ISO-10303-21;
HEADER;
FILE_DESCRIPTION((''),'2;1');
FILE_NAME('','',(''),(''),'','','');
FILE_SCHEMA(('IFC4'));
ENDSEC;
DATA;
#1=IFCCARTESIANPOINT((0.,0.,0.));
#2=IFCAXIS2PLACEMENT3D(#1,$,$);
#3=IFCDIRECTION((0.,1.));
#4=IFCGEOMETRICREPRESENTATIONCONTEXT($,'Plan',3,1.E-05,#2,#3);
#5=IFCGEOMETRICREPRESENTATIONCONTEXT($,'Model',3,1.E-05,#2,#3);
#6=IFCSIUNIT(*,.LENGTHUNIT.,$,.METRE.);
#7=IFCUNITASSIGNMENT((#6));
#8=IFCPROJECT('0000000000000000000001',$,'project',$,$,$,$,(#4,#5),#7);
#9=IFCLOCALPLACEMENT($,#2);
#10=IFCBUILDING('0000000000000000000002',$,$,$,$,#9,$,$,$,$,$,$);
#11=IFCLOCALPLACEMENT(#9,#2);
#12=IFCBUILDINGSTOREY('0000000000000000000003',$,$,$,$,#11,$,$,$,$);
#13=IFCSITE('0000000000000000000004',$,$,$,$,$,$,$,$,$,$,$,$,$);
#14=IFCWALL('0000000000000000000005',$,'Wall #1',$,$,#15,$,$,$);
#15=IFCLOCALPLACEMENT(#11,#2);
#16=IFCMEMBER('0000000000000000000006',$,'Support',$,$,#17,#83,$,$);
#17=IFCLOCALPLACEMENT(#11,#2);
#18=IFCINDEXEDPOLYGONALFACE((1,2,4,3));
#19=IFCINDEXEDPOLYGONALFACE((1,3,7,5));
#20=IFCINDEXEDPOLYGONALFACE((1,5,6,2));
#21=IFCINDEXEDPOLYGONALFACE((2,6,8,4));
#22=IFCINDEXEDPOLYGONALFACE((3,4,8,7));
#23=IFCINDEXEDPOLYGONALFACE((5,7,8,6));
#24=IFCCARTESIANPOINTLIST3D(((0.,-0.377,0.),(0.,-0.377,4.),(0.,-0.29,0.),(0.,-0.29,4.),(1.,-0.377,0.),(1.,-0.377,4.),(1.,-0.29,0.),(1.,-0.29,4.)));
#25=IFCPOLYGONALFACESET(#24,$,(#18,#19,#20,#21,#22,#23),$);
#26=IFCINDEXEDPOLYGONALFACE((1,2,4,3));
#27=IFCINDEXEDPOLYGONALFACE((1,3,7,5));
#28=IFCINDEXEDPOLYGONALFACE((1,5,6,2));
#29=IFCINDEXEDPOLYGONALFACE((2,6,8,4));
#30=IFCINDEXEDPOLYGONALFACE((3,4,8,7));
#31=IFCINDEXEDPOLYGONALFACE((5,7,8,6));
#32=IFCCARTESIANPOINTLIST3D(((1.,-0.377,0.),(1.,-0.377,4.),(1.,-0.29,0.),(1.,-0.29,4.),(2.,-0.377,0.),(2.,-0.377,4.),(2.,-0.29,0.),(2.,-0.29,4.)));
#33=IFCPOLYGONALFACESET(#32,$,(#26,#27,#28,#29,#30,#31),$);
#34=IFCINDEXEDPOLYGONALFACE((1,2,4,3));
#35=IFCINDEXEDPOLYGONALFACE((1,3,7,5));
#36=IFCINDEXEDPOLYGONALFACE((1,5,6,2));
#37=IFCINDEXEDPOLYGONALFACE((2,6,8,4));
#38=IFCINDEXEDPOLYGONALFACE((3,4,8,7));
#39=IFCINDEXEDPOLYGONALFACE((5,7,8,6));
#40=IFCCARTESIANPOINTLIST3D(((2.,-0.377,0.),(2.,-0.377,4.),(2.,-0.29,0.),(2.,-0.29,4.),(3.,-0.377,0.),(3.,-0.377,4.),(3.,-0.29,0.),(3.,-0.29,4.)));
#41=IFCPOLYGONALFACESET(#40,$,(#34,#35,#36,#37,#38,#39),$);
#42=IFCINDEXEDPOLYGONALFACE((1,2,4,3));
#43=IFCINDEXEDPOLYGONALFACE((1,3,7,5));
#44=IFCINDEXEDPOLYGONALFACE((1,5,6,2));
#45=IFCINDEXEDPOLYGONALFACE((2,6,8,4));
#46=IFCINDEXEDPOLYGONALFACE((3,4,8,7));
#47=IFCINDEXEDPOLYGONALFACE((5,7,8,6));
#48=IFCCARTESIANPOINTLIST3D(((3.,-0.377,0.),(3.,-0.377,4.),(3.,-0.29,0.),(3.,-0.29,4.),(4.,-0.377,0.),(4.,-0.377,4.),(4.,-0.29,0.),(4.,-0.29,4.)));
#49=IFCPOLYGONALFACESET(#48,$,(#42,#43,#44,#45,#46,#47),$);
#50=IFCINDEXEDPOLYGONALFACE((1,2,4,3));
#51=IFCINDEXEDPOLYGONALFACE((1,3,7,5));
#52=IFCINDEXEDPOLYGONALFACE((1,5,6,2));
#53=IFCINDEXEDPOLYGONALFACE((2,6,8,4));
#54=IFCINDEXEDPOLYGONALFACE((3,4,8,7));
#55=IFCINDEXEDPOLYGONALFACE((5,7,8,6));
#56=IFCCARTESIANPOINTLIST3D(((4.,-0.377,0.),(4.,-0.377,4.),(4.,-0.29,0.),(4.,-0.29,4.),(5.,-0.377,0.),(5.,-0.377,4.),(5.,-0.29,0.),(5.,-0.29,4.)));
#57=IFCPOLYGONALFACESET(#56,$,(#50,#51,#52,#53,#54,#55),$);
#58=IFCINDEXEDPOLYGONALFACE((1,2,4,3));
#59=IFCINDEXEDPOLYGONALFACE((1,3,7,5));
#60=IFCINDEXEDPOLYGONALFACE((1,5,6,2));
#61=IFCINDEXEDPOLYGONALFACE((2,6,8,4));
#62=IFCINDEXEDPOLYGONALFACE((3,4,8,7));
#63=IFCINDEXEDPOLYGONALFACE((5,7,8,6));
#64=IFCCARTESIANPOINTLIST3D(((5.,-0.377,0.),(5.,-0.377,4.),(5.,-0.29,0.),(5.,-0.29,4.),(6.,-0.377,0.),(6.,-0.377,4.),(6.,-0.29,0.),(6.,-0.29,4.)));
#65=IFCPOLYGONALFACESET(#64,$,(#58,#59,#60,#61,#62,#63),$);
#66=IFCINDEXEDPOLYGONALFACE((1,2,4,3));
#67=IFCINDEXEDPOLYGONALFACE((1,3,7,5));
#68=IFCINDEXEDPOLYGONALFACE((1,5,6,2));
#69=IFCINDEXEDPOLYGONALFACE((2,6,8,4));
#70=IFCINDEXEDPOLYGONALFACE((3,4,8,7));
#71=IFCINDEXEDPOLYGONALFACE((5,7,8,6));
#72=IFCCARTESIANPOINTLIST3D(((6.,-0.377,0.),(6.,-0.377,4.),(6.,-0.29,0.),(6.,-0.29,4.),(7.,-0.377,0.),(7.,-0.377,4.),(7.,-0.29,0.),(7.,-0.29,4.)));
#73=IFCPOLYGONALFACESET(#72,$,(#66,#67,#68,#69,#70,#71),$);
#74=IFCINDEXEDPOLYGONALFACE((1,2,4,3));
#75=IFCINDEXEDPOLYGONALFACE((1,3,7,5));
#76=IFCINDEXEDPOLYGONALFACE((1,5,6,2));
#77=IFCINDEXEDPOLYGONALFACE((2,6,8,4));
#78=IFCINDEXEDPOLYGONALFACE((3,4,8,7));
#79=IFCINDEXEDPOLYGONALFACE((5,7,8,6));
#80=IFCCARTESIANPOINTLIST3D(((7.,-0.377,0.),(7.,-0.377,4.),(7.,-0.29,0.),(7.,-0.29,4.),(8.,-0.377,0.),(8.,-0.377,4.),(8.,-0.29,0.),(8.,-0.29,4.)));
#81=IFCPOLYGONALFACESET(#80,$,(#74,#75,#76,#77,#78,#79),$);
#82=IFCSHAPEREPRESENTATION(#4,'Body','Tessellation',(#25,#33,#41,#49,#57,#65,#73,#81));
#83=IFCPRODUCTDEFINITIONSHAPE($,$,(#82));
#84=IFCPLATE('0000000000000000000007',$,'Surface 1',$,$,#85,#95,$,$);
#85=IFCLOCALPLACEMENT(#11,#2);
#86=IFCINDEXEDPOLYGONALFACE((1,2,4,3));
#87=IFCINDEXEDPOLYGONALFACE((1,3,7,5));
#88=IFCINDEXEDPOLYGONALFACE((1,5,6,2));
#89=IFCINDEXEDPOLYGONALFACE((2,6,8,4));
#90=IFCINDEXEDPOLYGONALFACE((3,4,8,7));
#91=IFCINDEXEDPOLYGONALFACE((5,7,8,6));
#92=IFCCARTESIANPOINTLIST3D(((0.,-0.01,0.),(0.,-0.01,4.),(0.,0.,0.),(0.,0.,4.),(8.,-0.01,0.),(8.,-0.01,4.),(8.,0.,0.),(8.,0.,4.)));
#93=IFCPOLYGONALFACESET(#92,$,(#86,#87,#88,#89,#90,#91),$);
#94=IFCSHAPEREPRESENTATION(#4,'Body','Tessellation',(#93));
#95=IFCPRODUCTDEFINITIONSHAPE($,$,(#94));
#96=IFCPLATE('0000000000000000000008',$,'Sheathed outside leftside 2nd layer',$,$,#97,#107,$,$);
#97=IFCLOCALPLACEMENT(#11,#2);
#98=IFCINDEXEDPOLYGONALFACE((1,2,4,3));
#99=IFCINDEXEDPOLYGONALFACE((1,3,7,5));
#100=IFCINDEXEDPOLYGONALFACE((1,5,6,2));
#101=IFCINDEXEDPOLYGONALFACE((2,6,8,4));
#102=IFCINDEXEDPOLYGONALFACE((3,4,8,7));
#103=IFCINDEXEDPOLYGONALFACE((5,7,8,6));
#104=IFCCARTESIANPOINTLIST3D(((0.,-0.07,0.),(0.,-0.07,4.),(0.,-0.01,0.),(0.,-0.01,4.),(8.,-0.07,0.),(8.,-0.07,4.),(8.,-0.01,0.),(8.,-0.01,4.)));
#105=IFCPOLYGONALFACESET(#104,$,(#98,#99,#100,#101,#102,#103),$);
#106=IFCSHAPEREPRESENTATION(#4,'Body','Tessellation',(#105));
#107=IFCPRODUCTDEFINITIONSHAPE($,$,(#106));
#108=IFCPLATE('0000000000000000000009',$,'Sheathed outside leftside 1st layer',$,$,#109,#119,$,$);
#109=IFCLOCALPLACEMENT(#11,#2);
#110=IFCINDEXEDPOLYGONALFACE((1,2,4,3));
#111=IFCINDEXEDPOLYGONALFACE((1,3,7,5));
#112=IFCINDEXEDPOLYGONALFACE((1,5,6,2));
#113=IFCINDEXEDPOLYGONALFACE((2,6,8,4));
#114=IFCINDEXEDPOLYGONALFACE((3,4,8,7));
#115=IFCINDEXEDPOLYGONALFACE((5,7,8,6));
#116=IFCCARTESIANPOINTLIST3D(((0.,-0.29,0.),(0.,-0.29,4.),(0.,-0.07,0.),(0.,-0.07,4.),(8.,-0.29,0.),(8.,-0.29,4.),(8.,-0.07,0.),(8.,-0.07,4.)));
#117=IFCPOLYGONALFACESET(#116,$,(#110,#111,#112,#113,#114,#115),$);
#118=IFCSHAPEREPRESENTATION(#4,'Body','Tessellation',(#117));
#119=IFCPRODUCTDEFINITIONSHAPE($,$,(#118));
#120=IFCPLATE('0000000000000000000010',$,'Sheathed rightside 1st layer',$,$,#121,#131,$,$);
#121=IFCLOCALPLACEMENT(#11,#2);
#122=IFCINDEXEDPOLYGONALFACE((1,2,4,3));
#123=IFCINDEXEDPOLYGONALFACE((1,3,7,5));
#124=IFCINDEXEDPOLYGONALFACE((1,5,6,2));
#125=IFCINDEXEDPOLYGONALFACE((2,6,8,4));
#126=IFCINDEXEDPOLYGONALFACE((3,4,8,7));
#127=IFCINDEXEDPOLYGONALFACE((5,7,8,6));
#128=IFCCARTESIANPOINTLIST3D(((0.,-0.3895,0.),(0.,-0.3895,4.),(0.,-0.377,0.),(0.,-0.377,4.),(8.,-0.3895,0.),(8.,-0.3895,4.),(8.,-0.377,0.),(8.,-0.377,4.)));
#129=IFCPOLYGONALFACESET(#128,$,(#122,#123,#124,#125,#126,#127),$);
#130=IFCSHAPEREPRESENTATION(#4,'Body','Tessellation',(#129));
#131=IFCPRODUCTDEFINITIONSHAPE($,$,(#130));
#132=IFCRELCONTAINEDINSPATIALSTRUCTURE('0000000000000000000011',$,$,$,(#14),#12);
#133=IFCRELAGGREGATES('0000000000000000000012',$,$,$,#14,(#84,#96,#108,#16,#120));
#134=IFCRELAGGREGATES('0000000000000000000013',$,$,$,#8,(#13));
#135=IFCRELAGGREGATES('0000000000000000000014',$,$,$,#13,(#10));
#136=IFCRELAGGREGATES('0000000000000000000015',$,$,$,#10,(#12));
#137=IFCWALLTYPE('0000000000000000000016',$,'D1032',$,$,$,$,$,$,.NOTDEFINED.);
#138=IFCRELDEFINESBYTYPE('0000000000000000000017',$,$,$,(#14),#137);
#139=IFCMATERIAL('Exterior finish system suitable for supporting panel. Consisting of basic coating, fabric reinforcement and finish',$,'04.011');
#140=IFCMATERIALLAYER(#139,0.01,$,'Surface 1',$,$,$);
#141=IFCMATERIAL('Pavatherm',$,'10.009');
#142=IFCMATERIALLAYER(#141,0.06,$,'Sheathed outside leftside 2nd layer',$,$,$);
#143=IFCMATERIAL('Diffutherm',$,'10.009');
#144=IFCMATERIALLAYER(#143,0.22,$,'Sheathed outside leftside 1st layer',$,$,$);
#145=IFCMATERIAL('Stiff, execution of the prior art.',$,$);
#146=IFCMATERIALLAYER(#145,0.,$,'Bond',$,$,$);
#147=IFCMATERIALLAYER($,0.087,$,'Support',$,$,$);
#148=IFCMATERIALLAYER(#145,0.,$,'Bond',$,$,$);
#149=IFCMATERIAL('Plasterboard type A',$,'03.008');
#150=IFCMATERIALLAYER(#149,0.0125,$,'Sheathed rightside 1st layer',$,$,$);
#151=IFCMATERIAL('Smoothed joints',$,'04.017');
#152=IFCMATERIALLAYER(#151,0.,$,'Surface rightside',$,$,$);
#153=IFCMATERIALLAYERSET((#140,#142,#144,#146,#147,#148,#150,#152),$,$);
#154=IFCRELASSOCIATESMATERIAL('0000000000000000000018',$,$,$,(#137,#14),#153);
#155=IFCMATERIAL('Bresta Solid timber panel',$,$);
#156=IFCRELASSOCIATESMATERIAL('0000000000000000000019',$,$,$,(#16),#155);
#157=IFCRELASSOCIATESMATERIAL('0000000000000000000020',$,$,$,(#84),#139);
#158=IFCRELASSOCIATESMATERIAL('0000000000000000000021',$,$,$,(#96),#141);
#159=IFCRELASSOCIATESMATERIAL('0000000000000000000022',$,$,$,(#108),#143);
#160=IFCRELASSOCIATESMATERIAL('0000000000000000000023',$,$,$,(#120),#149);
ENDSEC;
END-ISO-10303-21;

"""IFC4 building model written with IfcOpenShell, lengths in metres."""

from ifc_helpers import new_model, si_unit, direction, frame, frame_2d, origin, origin_with_axes, place, context, project, spatial, rectangle, extrude, material, layer, layer_set, type_object, element, aggregate, save


model = new_model("IFC4")

# Units and contexts
plan_context = context("Plan", 3, precision=1e-05, world=origin(), true_north=direction((0.0, 1.0)))
model_context = context("Model", 3, precision=1e-05, world=origin(), true_north=direction((0.0, 1.0)))
ifc_project = project(units=[si_unit("LENGTHUNIT", "METRE")], contexts=[plan_context, model_context])

# Site, building, storey
site = spatial("IfcSite", under=ifc_project)
building_placement = place(None, origin())
building = spatial("IfcBuilding", under=site, at=building_placement)
storey_placement = place(building_placement, origin())
storey = spatial("IfcBuildingStorey", under=building, at=storey_placement)

# Wall, member, plates
ifc_material_1 = material(Name="Exterior finish system suitable for supporting panel. Consisting of basic coating, fabric reinforcement and finish", Category="04.011")
ifc_layer_1 = layer(ifc_material_1, 0.01, Name="Surface 1")
ifc_material_2 = material(Name="Pavatherm", Category="10.009")
ifc_layer_2 = layer(ifc_material_2, 0.06, Name="Sheathed outside leftside 2nd layer")
ifc_material_3 = material(Name="Diffutherm", Category="10.009")
ifc_layer_3 = layer(ifc_material_3, 0.22, Name="Sheathed outside leftside 1st layer")
ifc_material_4 = material(Name="Stiff, execution of the prior art.")
ifc_layer_4 = layer(ifc_material_4, 0.0, Name="Bond")
ifc_layer_5 = layer(None, 0.087, Name="Support")
ifc_layer_6 = layer(ifc_material_4, 0.0, Name="Bond")
ifc_material_5 = material(Name="Plasterboard type A", Category="03.008")
ifc_layer_7 = layer(ifc_material_5, 0.0125, Name="Sheathed rightside 1st layer")
ifc_material_6 = material(Name="Smoothed joints", Category="04.017")
ifc_layer_8 = layer(ifc_material_6, 0.0, Name="Surface rightside")
ifc_layer_set = layer_set([ifc_layer_1, ifc_layer_2, ifc_layer_3, ifc_layer_4, ifc_layer_5, ifc_layer_6, ifc_layer_7, ifc_layer_8])
wall_type = type_object("IfcWallType", Name="D1032", PredefinedType="NOTDEFINED", material=ifc_layer_set)
wall_placement = place(None, frame((0.0, 0.0, 0.0), z_axis=(0.0, -1.0, 0.0), x_axis=(1.0, 0.0, 0.0)))
wall = element("IfcWall", 1, at=wall_placement, inside=storey, type_object=wall_type, material=ifc_layer_set, Name="Wall #1")
ifc_material_7 = material(Name="Bresta Solid timber panel")
member_placement = place(wall_placement, origin())
member = element("IfcMember", 2, at=member_placement, material=ifc_material_7, Name="Support", context=plan_context, shape_type="SweptSolid", body=[
    extrude(rectangle(XDim=1.0, YDim=0.087, at=frame_2d((0.5, 0.0435), x_axis=(1.0, 0.0))), frame((0.0, 4.0, 0.29), z_axis=(0.0, -1.0, 0.0), x_axis=(1.0, 0.0, 0.0)), (0.0, 0.0, 1.0), 4.0),
    extrude(rectangle(XDim=1.0, YDim=0.087, at=frame_2d((0.5, 0.0435), x_axis=(1.0, 0.0))), frame((1.0, 4.0, 0.29), z_axis=(0.0, -1.0, 0.0), x_axis=(1.0, 0.0, 0.0)), (0.0, 0.0, 1.0), 4.0),
    extrude(rectangle(XDim=1.0, YDim=0.087, at=frame_2d((0.5, 0.0435), x_axis=(1.0, 0.0))), frame((2.0, 4.0, 0.29), z_axis=(0.0, -1.0, 0.0), x_axis=(1.0, 0.0, 0.0)), (0.0, 0.0, 1.0), 4.0),
    extrude(rectangle(XDim=1.0, YDim=0.087, at=frame_2d((0.5, 0.0435), x_axis=(1.0, 0.0))), frame((3.0, 4.0, 0.29), z_axis=(0.0, -1.0, 0.0), x_axis=(1.0, 0.0, 0.0)), (0.0, 0.0, 1.0), 4.0),
    extrude(rectangle(XDim=1.0, YDim=0.087, at=frame_2d((0.5, 0.0435), x_axis=(1.0, 0.0))), frame((4.0, 4.0, 0.29), z_axis=(0.0, -1.0, 0.0), x_axis=(1.0, 0.0, 0.0)), (0.0, 0.0, 1.0), 4.0),
    extrude(rectangle(XDim=1.0, YDim=0.087, at=frame_2d((0.5, 0.0435), x_axis=(1.0, 0.0))), frame((5.0, 4.0, 0.29), z_axis=(0.0, -1.0, 0.0), x_axis=(1.0, 0.0, 0.0)), (0.0, 0.0, 1.0), 4.0),
    extrude(rectangle(XDim=1.0, YDim=0.087, at=frame_2d((0.5, 0.0435), x_axis=(1.0, 0.0))), frame((6.0, 4.0, 0.29), z_axis=(0.0, -1.0, 0.0), x_axis=(1.0, 0.0, 0.0)), (0.0, 0.0, 1.0), 4.0),
    extrude(rectangle(XDim=1.0, YDim=0.087, at=frame_2d((0.5, 0.0435), x_axis=(1.0, 0.0))), frame((7.0, 4.0, 0.29), z_axis=(0.0, -1.0, 0.0), x_axis=(1.0, 0.0, 0.0)), (0.0, 0.0, 1.0), 4.0),
])
plate_1_placement = place(wall_placement, origin())
plate_1 = element("IfcPlate", 3, at=plate_1_placement, material=ifc_material_1, Name="Surface 1", context=plan_context, shape_type="SweptSolid", body=[
    extrude(rectangle(XDim=8.0, YDim=4.0, at=frame_2d((4.0, 2.0), x_axis=(1.0, 0.0))), origin_with_axes(), (0.0, 0.0, 1.0), 0.01),
])
plate_2_placement = place(wall_placement, origin())
plate_2 = element("IfcPlate", 4, at=plate_2_placement, material=ifc_material_2, Name="Sheathed outside leftside 2nd layer", context=plan_context, shape_type="SweptSolid", body=[
    extrude(rectangle(XDim=8.0, YDim=4.0, at=frame_2d((4.0, 2.0), x_axis=(1.0, 0.0))), frame((0.0, 0.0, 0.01), z_axis=(0.0, 0.0, 1.0), x_axis=(1.0, 0.0, 0.0)), (0.0, 0.0, 1.0), 0.06),
])
plate_3_placement = place(wall_placement, origin())
plate_3 = element("IfcPlate", 5, at=plate_3_placement, material=ifc_material_3, Name="Sheathed outside leftside 1st layer", context=plan_context, shape_type="SweptSolid", body=[
    extrude(rectangle(XDim=8.0, YDim=4.0, at=frame_2d((4.0, 2.0), x_axis=(1.0, 0.0))), frame((0.0, 0.0, 0.07), z_axis=(0.0, 0.0, 1.0), x_axis=(1.0, 0.0, 0.0)), (0.0, 0.0, 1.0), 0.22),
])
plate_4_placement = place(wall_placement, origin())
plate_4 = element("IfcPlate", 6, at=plate_4_placement, material=ifc_material_5, Name="Sheathed rightside 1st layer", context=plan_context, shape_type="SweptSolid", body=[
    extrude(rectangle(XDim=8.0, YDim=4.0, at=frame_2d((4.0, 2.0), x_axis=(1.0, 0.0))), frame((0.0, 0.0, 0.377), z_axis=(0.0, 0.0, 1.0), x_axis=(1.0, 0.0, 0.0)), (0.0, 0.0, 1.0), 0.0125),
])
aggregate(wall, [plate_1, plate_2, plate_3, member, plate_4])

save(model, "model.ifc")
